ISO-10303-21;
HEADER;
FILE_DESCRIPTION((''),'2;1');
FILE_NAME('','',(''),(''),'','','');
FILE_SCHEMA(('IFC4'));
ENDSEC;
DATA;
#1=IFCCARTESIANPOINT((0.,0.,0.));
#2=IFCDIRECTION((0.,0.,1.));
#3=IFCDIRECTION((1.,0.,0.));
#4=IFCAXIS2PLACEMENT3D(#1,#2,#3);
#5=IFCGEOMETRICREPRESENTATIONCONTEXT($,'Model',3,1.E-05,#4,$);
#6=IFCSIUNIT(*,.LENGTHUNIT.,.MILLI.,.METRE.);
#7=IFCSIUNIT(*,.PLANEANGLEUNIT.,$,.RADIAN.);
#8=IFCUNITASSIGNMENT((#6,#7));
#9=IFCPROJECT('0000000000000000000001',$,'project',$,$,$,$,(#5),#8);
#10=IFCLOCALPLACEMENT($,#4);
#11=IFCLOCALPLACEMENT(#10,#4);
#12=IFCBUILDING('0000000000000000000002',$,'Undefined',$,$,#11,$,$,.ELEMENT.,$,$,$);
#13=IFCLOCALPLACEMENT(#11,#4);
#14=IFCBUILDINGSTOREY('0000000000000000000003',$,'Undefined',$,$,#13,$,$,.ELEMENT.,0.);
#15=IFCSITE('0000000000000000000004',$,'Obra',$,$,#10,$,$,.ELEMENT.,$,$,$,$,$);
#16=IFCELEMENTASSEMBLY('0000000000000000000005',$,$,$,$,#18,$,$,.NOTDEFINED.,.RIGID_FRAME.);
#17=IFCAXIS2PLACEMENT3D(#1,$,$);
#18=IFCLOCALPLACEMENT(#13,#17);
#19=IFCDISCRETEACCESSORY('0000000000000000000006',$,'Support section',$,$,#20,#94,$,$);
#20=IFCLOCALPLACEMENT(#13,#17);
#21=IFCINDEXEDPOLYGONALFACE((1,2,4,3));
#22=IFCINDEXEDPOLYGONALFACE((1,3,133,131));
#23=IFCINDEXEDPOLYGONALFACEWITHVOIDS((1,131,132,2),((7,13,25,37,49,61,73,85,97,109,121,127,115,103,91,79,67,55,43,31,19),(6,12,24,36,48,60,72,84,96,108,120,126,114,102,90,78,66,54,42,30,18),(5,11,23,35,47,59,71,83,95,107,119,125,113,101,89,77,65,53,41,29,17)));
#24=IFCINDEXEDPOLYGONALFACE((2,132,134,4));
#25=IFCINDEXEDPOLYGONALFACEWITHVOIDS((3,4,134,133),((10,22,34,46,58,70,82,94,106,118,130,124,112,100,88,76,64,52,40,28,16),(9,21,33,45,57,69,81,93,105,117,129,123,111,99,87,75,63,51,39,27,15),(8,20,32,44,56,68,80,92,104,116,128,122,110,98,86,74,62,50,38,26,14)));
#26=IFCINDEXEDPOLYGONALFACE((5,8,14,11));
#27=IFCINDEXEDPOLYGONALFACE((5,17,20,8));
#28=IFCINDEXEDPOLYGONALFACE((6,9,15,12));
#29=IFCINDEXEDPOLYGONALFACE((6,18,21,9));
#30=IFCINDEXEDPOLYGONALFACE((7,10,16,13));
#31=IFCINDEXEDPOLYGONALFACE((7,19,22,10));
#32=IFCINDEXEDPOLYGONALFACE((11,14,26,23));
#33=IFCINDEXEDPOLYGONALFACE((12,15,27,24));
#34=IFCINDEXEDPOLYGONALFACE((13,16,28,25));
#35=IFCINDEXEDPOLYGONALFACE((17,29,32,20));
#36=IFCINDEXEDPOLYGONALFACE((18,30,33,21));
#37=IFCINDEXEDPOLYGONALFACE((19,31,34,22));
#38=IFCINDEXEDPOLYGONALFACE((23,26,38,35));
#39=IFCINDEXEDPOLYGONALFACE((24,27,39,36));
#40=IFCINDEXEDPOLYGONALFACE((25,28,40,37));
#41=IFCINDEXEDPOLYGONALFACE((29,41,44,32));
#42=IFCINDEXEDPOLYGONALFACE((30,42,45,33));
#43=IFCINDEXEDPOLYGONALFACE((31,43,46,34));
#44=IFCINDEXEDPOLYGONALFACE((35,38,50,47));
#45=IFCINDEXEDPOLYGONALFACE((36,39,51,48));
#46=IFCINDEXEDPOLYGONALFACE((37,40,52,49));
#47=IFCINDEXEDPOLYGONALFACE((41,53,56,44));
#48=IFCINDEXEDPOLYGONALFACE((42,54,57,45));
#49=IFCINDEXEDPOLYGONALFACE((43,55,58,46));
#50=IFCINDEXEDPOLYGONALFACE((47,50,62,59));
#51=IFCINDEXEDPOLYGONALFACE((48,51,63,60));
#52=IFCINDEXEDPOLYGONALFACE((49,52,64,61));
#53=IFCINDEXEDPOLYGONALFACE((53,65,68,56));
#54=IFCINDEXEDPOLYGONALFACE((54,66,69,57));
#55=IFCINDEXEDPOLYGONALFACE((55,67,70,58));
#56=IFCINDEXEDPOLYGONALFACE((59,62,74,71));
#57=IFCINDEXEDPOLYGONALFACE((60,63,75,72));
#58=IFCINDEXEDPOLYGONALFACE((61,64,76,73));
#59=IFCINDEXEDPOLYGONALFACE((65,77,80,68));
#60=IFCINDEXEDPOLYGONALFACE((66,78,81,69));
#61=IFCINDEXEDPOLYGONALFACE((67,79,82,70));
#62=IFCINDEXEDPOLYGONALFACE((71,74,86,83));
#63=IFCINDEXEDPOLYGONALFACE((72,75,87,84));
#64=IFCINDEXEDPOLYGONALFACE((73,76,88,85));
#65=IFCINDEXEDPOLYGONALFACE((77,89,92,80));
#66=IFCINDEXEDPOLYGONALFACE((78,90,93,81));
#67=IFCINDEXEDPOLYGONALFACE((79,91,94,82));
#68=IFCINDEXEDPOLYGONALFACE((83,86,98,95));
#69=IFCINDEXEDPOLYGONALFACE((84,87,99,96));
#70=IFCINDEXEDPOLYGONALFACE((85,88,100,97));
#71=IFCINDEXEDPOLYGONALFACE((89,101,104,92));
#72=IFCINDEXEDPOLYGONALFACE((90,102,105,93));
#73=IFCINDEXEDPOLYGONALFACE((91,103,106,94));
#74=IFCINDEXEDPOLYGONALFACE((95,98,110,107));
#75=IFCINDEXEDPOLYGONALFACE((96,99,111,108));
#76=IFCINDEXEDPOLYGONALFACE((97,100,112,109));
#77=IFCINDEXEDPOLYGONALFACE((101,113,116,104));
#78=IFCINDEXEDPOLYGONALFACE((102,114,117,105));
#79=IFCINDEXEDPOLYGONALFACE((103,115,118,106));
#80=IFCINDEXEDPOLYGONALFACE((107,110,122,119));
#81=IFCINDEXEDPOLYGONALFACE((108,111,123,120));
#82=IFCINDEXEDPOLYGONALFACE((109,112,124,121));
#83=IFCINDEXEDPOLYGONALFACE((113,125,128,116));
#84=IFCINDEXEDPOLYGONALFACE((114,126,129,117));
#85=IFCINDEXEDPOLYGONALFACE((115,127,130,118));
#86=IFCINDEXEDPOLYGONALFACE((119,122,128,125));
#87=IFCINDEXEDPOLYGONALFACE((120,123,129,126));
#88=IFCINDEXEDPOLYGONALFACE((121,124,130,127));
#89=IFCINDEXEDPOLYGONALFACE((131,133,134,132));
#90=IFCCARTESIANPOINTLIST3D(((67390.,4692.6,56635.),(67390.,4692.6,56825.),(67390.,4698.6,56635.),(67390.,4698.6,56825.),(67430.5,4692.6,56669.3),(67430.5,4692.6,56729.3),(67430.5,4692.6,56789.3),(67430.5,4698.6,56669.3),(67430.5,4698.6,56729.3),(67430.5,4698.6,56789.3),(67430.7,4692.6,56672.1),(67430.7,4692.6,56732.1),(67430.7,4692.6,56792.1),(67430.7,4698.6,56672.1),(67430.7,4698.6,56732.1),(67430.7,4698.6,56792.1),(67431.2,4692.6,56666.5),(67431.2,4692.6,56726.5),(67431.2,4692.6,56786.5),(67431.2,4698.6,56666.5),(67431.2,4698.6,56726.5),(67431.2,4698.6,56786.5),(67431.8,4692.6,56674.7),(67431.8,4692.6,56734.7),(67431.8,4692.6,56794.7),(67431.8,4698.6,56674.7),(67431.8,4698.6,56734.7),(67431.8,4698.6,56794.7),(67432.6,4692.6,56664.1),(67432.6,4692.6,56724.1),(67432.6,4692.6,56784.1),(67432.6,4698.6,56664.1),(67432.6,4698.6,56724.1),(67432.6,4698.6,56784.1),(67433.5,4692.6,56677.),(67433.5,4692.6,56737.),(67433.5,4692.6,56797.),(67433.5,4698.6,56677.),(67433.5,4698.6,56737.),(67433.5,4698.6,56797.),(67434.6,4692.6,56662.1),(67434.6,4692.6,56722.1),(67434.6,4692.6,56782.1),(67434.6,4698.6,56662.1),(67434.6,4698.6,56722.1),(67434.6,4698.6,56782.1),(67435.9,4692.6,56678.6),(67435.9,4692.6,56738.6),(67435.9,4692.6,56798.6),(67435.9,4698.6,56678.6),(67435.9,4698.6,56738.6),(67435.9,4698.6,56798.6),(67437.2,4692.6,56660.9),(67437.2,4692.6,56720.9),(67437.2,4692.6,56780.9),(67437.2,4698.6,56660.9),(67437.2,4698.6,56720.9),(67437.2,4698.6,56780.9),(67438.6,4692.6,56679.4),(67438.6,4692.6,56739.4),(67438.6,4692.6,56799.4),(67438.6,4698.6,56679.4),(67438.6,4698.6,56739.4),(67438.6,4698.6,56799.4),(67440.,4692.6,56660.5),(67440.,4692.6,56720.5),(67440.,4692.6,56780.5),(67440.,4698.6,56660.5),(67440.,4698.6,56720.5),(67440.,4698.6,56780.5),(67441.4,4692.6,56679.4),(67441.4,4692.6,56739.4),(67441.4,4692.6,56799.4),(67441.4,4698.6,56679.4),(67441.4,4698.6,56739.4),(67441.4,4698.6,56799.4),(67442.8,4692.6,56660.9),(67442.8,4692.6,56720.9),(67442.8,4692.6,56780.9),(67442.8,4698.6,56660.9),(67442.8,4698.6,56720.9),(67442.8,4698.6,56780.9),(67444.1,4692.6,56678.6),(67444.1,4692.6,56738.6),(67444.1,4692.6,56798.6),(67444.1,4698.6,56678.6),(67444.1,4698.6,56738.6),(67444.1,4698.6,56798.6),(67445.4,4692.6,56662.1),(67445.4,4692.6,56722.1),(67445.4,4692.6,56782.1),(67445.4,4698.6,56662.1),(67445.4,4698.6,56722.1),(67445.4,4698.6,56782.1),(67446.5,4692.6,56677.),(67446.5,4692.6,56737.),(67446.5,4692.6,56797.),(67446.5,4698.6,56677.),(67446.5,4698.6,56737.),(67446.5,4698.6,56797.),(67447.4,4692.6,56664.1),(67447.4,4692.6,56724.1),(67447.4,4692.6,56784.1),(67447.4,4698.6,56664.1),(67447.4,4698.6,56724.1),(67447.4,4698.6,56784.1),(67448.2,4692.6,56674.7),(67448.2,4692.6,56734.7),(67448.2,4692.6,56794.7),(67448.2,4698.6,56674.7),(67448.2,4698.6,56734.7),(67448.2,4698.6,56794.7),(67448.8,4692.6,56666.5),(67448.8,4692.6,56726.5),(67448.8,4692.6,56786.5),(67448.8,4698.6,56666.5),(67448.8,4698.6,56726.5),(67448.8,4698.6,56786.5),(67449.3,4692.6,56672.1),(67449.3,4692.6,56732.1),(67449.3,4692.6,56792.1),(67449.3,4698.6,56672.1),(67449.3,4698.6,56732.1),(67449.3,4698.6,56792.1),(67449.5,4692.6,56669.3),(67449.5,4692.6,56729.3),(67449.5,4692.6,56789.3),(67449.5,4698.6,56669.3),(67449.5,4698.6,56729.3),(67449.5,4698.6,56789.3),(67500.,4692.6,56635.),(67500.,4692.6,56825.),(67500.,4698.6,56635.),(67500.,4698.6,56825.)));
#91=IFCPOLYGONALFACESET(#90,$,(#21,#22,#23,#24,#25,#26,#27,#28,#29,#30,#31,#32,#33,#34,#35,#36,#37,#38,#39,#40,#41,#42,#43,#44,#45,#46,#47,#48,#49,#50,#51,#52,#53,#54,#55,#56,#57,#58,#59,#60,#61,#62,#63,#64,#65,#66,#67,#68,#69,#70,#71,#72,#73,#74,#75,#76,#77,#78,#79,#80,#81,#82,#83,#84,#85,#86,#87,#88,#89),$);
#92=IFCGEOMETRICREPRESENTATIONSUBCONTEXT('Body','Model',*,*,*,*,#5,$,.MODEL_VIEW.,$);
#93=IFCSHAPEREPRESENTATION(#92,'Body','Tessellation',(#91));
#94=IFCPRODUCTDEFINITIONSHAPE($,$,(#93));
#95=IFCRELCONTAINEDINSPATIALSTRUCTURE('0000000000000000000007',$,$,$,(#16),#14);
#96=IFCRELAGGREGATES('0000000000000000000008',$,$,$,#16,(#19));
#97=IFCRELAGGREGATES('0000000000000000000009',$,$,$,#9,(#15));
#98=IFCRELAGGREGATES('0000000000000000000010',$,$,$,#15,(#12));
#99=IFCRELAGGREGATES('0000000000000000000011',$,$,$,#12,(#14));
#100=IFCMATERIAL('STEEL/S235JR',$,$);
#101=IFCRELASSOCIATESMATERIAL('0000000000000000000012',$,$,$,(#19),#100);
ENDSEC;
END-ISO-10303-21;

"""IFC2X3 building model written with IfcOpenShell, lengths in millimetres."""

from ifc_helpers import new_model, si_unit, frame, origin_with_axes, origin_2d_with_axis, place, context, subcontext, project, spatial, rectangle, circle, extrude, source, transform, mapped, material, element, aggregate, save


model = new_model("IFC2X3")

# Units and contexts
model_context = context("Model", 3, precision=1e-05, world=origin_with_axes())
body_context = subcontext(model_context, "Body", "Model", "MODEL_VIEW")
ifc_project = project(units=[si_unit("LENGTHUNIT", "METRE", prefix="MILLI"), si_unit("PLANEANGLEUNIT", "RADIAN")], contexts=[model_context])

# Site, building, storey
site_placement = place(None, origin_with_axes())
site = spatial("IfcSite", under=ifc_project, at=site_placement, Name="Obra", CompositionType="ELEMENT")
building_placement = place(site_placement, origin_with_axes())
building = spatial("IfcBuilding", under=site, at=building_placement, Name="Undefined", CompositionType="ELEMENT")
storey_placement = place(building_placement, origin_with_axes())
storey = spatial("IfcBuildingStorey", under=building, at=storey_placement, Name="Undefined", CompositionType="ELEMENT", Elevation=0.0)

# Element assembly
ifc_material_1 = material(Name="STEEL/S235JR")
assembly_1_placement = place(storey_placement, origin_with_axes())
assembly_1 = element("IfcElementAssembly", 1, at=assembly_1_placement, inside=storey, AssemblyPlace="NOTDEFINED", PredefinedType="RIGID_FRAME")

# Discrete accessory, opening
shared_shape_1 = source(origin_with_axes(), body_context, "Body", "SweptSolid", [
    extrude(circle(Radius=9.5, at=origin_2d_with_axis()), frame((0.0, -9.2, 0.0), z_axis=(0.0, 1.0, 0.0), x_axis=(1.0, 0.0, 0.0)), (0.0, 0.0, 1.0), 6.2),
])
discrete_accessory_1_placement = place(assembly_1_placement, frame((67445.0, 4695.6, 56635.0), z_axis=(0.0, 0.0, 1.0), x_axis=(1.0, 0.0, 0.0)))
discrete_accessory_1 = element("IfcDiscreteAccessory", 2, at=discrete_accessory_1_placement, material=ifc_material_1, Name="Support section", context=body_context, shape_type="SweptSolid", body=[
    extrude(rectangle(XDim=6.0, YDim=110.0, at=origin_2d_with_axis()), frame((0.0, 0.0, 190.0), z_axis=(0.0, 0.0, -1.0), x_axis=(0.0, 1.0, 0.0)), (0.0, 0.0, 1.0), 190.0),
])
opening_1_placement = place(assembly_1_placement, frame((67490.0, 4689.5, 56850.0), z_axis=(-1.0, 0.0, 0.0), x_axis=(0.0, 0.0, -1.0)))
element("IfcOpeningElement", 3, at=opening_1_placement, cuts=discrete_accessory_1, ObjectType="Opening", context=body_context, shape_type="MappedRepresentation", body=[
    mapped(shared_shape_1, transform((60.0, 0.0, 50.0))),
    mapped(shared_shape_1, transform((120.0, 0.0, 50.0))),
    mapped(shared_shape_1, transform((180.0, 0.0, 50.0))),
])
aggregate(assembly_1, [discrete_accessory_1])

save(model, "model.ifc")
